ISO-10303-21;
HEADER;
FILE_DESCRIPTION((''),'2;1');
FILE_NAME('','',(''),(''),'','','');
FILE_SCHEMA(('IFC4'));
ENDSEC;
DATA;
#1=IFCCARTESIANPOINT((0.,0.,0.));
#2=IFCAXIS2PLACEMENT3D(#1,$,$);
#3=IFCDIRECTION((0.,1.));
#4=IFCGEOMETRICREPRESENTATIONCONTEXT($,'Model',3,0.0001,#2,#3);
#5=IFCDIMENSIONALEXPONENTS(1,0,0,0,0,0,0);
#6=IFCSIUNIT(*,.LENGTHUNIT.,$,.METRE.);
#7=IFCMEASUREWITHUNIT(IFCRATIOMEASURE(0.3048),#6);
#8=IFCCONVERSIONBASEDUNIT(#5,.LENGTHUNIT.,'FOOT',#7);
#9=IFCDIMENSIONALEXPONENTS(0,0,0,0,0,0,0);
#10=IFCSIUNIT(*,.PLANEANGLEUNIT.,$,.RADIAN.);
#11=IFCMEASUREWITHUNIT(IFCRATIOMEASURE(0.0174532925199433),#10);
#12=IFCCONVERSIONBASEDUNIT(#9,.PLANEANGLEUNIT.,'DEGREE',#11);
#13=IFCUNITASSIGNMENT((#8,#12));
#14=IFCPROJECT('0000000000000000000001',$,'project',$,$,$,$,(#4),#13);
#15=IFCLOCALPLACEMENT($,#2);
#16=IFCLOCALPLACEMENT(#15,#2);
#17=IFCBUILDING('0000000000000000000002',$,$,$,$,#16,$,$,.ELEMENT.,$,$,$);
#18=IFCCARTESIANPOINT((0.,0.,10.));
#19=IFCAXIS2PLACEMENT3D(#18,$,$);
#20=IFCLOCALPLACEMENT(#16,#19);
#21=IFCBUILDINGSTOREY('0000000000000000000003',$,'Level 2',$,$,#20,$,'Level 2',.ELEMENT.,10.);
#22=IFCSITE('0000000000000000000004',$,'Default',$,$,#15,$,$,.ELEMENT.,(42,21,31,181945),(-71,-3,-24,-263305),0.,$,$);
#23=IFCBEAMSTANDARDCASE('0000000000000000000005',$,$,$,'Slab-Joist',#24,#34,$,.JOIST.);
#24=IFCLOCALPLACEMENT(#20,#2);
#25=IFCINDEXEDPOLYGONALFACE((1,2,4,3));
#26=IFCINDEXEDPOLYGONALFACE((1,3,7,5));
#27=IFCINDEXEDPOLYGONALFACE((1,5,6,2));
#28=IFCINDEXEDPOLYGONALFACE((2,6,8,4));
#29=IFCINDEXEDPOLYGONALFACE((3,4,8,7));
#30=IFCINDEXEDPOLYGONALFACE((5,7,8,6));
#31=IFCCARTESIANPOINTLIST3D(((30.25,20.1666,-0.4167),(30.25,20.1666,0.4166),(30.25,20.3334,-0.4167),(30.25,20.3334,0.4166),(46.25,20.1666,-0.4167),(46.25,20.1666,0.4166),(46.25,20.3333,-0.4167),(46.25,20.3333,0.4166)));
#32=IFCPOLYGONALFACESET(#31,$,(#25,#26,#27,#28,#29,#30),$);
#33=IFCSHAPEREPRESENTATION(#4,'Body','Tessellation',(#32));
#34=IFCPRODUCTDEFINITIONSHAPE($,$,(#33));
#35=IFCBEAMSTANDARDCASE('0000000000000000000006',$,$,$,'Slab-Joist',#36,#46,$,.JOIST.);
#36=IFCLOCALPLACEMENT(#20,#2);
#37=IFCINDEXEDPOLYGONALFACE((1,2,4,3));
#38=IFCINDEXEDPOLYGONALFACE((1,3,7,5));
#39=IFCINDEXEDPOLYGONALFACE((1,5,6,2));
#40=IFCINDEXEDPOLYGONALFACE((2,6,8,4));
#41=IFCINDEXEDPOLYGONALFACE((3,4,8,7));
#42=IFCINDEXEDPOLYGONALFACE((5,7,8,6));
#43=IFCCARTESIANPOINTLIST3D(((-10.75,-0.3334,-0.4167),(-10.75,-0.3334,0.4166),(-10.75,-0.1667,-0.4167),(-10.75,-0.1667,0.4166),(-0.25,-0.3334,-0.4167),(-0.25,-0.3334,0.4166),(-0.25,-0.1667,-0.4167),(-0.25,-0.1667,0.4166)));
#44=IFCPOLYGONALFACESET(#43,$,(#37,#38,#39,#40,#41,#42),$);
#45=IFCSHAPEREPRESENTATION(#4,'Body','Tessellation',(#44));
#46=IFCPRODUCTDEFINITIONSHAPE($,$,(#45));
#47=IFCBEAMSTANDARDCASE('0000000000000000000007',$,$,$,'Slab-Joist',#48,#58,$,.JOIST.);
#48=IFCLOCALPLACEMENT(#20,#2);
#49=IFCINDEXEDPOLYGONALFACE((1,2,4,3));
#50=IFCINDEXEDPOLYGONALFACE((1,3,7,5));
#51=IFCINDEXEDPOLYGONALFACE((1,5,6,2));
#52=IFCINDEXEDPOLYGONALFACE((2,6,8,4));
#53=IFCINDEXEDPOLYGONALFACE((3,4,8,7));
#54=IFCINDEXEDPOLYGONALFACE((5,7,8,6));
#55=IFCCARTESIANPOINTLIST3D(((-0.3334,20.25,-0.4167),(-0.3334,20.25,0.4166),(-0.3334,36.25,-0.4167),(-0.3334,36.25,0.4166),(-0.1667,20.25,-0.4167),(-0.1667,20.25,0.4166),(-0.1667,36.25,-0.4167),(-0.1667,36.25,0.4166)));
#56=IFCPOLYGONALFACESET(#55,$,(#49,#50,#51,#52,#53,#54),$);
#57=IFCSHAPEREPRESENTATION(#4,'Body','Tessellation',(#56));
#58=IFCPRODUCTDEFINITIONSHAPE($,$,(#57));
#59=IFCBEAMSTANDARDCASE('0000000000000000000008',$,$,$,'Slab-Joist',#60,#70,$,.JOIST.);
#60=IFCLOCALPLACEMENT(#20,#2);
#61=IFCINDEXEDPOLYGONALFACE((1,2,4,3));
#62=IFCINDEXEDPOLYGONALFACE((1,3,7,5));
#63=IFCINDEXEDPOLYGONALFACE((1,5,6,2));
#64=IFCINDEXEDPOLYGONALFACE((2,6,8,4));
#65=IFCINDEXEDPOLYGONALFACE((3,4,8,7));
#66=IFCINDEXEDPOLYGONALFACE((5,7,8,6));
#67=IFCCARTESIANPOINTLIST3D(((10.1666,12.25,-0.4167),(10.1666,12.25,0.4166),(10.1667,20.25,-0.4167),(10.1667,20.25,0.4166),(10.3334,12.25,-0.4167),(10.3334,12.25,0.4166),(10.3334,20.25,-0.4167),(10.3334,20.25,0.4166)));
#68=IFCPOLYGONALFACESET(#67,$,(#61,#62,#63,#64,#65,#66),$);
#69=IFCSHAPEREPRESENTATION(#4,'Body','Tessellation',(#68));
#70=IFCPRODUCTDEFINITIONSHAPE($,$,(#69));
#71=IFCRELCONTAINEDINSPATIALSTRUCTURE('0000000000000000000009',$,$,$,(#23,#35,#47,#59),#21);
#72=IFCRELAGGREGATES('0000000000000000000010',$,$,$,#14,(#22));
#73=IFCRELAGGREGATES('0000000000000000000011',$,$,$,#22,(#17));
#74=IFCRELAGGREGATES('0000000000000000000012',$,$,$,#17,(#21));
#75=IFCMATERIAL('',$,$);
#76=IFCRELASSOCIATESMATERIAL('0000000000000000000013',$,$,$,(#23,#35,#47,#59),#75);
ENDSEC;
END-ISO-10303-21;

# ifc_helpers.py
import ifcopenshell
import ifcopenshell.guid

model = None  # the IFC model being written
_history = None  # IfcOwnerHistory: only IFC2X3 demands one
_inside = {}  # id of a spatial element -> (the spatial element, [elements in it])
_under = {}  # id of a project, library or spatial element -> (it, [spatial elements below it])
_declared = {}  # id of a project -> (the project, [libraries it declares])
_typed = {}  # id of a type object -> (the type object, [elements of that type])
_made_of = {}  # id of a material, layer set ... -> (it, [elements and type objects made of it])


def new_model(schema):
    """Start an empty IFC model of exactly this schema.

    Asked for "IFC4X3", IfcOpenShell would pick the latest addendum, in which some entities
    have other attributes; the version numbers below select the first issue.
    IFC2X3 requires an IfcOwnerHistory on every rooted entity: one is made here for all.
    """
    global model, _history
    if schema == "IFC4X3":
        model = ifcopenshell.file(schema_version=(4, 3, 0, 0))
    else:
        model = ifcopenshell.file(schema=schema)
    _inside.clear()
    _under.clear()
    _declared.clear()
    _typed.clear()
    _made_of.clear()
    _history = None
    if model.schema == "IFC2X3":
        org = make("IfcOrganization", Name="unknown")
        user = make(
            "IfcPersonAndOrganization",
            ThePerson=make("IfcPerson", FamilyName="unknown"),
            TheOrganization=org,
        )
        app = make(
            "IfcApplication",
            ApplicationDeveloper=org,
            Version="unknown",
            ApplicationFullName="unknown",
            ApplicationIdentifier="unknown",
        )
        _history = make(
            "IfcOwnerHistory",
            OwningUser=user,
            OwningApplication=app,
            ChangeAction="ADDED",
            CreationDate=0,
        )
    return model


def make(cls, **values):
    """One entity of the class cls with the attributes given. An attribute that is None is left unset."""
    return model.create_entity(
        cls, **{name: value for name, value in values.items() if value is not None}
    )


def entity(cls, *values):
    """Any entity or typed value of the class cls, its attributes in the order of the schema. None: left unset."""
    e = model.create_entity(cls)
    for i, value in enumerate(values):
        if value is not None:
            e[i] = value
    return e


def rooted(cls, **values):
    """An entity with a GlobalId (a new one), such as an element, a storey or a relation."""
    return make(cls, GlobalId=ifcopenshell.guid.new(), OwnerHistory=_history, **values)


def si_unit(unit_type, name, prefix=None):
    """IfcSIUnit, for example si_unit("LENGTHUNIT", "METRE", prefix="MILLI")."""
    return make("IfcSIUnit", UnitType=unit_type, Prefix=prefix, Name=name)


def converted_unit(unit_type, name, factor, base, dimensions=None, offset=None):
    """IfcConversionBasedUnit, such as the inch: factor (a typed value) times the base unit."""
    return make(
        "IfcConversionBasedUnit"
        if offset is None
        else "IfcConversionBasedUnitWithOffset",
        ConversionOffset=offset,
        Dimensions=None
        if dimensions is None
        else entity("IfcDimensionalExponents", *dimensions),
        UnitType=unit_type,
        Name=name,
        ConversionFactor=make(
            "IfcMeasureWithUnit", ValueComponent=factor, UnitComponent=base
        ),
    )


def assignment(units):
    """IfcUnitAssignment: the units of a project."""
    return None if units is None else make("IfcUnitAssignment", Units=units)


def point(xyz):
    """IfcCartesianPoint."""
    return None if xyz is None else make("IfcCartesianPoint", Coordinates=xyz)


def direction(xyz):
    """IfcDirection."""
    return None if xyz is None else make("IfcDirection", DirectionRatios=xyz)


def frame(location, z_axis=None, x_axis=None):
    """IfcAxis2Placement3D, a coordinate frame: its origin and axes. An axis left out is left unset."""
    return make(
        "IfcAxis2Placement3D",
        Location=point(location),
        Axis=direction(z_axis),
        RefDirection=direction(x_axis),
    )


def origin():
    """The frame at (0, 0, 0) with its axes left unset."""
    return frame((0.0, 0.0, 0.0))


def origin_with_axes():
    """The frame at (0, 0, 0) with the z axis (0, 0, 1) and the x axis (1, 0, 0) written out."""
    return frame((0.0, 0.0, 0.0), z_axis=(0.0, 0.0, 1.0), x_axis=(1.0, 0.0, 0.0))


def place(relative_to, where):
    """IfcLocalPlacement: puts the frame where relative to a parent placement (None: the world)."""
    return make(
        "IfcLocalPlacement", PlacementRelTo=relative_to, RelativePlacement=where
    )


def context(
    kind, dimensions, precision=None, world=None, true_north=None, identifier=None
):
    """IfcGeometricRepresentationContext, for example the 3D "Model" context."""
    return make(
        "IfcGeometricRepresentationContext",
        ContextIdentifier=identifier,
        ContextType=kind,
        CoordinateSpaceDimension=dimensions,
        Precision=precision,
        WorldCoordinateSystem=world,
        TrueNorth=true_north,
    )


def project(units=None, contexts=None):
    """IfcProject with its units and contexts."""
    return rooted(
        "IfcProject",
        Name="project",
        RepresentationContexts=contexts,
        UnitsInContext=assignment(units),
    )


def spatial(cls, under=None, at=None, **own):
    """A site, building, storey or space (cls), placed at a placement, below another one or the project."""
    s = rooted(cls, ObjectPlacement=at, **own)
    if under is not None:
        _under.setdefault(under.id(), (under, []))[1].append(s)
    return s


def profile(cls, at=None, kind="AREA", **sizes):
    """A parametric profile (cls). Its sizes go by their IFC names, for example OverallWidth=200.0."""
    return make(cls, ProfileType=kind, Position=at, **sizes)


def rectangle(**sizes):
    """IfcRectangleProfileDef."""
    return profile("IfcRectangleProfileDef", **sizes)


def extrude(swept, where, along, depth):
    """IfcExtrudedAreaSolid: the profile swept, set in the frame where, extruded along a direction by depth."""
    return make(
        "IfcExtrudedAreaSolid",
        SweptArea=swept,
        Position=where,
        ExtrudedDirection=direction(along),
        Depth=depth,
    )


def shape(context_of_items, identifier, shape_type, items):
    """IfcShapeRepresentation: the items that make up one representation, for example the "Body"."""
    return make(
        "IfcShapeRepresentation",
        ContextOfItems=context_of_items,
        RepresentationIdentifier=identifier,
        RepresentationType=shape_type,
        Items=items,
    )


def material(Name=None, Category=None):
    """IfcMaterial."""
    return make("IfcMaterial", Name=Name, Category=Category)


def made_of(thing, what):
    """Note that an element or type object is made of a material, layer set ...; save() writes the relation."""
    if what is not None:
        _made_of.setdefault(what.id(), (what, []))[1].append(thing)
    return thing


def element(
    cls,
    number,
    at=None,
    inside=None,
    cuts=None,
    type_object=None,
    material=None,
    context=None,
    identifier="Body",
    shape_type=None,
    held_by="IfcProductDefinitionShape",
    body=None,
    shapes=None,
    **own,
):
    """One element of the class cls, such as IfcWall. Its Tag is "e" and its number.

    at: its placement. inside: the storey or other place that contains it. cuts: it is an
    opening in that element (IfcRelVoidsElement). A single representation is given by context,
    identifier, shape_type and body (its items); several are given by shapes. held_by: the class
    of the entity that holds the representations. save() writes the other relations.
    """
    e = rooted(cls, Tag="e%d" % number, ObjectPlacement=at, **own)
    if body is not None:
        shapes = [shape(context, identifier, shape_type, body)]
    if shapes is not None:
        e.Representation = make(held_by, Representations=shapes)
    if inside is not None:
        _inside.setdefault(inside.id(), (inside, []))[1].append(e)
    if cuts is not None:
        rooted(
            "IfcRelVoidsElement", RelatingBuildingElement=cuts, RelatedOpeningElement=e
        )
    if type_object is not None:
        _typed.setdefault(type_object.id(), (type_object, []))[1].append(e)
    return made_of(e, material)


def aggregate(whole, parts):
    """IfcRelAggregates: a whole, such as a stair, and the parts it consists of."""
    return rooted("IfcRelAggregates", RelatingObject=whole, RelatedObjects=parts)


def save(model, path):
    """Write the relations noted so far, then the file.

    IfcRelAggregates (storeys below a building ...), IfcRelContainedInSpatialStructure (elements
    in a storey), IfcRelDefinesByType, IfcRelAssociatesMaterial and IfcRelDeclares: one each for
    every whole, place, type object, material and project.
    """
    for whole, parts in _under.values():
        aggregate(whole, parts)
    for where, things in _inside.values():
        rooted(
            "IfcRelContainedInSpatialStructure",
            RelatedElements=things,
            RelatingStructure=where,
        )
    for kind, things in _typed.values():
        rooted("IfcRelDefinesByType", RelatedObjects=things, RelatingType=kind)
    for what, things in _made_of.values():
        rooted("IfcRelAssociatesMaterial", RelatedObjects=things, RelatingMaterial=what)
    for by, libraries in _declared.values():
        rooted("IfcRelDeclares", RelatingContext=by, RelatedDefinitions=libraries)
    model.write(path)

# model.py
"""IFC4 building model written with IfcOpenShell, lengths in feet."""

from ifc_helpers import new_model, entity, si_unit, converted_unit, direction, frame, origin, origin_with_axes, place, context, project, spatial, rectangle, extrude, material, element, save


model = new_model("IFC4")

# Units and contexts
model_context = context("Model", 3, precision=0.0001, world=origin(), true_north=direction((0.0, 1.0)))
ifc_project = project(units=[converted_unit("LENGTHUNIT", "FOOT", entity("IfcRatioMeasure", 0.3048), si_unit("LENGTHUNIT", "METRE"), dimensions=[1, 0, 0, 0, 0, 0, 0]), converted_unit("PLANEANGLEUNIT", "DEGREE", entity("IfcRatioMeasure", 0.0174532925199433), si_unit("PLANEANGLEUNIT", "RADIAN"), dimensions=[0, 0, 0, 0, 0, 0, 0])], contexts=[model_context])

# Site, building, storey
site_placement = place(None, origin())
site = spatial("IfcSite", under=ifc_project, at=site_placement, Name="Default", CompositionType="ELEMENT", RefLatitude=(42, 21, 31, 181945), RefLongitude=(-71, -3, -24, -263305), RefElevation=0.0)
building_placement = place(site_placement, origin())
building = spatial("IfcBuilding", under=site, at=building_placement, CompositionType="ELEMENT")
storey_placement = place(building_placement, frame((0.0, 0.0, 10.0)))
storey = spatial("IfcBuildingStorey", under=building, at=storey_placement, Name="Level 2", LongName="Level 2", CompositionType="ELEMENT", Elevation=10.0)

# Beams
ifc_material = material(Name="")
placement_1 = place(storey_placement, frame((30.25, 20.25, 0.0), z_axis=(0.0, 0.0, 1.0), x_axis=(1.0, 0.0, 0.0)))
beam_1_placement = place(placement_1, frame((0.0, 0.0, 0.0), z_axis=(1.0, 0.0, 0.0), x_axis=(0.0, 1.0, 0.0)))
element("IfcBeamStandardCase", 1, at=beam_1_placement, inside=storey, material=ifc_material, ObjectType="Slab-Joist", PredefinedType="JOIST", context=model_context, shape_type="SweptSolid", body=[
    extrude(rectangle(XDim=0.1667, YDim=0.8333), origin_with_axes(), (0.0, 0.0, 1.0), 16.0),
])
placement_2 = place(storey_placement, frame((-0.25, -0.25, 0.0), z_axis=(0.0, 0.0, 1.0), x_axis=(1.0, 0.0, 0.0)))
beam_2_placement = place(placement_2, frame((0.0, 0.0, 0.0), z_axis=(-1.0, 0.0, 0.0), x_axis=(0.0, -1.0, 0.0)))
element("IfcBeamStandardCase", 2, at=beam_2_placement, inside=storey, material=ifc_material, ObjectType="Slab-Joist", PredefinedType="JOIST", context=model_context, shape_type="SweptSolid", body=[
    extrude(rectangle(XDim=0.1667, YDim=0.8333), origin_with_axes(), (0.0, 0.0, 1.0), 10.5),
])
placement_3 = place(storey_placement, frame((-0.25, 20.25, 0.0), z_axis=(0.0, 0.0, 1.0), x_axis=(1.0, 0.0, 0.0)))
beam_3_placement = place(placement_3, frame((0.0, 0.0, 0.0), z_axis=(0.0, 1.0, 0.0), x_axis=(-1.0, 0.0, 0.0)))
element("IfcBeamStandardCase", 3, at=beam_3_placement, inside=storey, material=ifc_material, ObjectType="Slab-Joist", PredefinedType="JOIST", context=model_context, shape_type="SweptSolid", body=[
    extrude(rectangle(XDim=0.1667, YDim=0.8333), origin_with_axes(), (0.0, 0.0, 1.0), 16.0),
])
placement_4 = place(storey_placement, frame((10.25, 12.25, 0.0), z_axis=(0.0, 0.0, 1.0), x_axis=(1.0, 0.0, 0.0)))
beam_4_placement = place(placement_4, frame((0.0, 0.0, 0.0), z_axis=(0.0, 1.0, 0.0), x_axis=(-1.0, 0.0, 0.0)))
element("IfcBeamStandardCase", 4, at=beam_4_placement, inside=storey, material=ifc_material, ObjectType="Slab-Joist", PredefinedType="JOIST", context=model_context, shape_type="SweptSolid", body=[
    extrude(rectangle(XDim=0.1667, YDim=0.8333), origin_with_axes(), (0.0, 0.0, 1.0), 8.0),
])

save(model, "model.ifc")
